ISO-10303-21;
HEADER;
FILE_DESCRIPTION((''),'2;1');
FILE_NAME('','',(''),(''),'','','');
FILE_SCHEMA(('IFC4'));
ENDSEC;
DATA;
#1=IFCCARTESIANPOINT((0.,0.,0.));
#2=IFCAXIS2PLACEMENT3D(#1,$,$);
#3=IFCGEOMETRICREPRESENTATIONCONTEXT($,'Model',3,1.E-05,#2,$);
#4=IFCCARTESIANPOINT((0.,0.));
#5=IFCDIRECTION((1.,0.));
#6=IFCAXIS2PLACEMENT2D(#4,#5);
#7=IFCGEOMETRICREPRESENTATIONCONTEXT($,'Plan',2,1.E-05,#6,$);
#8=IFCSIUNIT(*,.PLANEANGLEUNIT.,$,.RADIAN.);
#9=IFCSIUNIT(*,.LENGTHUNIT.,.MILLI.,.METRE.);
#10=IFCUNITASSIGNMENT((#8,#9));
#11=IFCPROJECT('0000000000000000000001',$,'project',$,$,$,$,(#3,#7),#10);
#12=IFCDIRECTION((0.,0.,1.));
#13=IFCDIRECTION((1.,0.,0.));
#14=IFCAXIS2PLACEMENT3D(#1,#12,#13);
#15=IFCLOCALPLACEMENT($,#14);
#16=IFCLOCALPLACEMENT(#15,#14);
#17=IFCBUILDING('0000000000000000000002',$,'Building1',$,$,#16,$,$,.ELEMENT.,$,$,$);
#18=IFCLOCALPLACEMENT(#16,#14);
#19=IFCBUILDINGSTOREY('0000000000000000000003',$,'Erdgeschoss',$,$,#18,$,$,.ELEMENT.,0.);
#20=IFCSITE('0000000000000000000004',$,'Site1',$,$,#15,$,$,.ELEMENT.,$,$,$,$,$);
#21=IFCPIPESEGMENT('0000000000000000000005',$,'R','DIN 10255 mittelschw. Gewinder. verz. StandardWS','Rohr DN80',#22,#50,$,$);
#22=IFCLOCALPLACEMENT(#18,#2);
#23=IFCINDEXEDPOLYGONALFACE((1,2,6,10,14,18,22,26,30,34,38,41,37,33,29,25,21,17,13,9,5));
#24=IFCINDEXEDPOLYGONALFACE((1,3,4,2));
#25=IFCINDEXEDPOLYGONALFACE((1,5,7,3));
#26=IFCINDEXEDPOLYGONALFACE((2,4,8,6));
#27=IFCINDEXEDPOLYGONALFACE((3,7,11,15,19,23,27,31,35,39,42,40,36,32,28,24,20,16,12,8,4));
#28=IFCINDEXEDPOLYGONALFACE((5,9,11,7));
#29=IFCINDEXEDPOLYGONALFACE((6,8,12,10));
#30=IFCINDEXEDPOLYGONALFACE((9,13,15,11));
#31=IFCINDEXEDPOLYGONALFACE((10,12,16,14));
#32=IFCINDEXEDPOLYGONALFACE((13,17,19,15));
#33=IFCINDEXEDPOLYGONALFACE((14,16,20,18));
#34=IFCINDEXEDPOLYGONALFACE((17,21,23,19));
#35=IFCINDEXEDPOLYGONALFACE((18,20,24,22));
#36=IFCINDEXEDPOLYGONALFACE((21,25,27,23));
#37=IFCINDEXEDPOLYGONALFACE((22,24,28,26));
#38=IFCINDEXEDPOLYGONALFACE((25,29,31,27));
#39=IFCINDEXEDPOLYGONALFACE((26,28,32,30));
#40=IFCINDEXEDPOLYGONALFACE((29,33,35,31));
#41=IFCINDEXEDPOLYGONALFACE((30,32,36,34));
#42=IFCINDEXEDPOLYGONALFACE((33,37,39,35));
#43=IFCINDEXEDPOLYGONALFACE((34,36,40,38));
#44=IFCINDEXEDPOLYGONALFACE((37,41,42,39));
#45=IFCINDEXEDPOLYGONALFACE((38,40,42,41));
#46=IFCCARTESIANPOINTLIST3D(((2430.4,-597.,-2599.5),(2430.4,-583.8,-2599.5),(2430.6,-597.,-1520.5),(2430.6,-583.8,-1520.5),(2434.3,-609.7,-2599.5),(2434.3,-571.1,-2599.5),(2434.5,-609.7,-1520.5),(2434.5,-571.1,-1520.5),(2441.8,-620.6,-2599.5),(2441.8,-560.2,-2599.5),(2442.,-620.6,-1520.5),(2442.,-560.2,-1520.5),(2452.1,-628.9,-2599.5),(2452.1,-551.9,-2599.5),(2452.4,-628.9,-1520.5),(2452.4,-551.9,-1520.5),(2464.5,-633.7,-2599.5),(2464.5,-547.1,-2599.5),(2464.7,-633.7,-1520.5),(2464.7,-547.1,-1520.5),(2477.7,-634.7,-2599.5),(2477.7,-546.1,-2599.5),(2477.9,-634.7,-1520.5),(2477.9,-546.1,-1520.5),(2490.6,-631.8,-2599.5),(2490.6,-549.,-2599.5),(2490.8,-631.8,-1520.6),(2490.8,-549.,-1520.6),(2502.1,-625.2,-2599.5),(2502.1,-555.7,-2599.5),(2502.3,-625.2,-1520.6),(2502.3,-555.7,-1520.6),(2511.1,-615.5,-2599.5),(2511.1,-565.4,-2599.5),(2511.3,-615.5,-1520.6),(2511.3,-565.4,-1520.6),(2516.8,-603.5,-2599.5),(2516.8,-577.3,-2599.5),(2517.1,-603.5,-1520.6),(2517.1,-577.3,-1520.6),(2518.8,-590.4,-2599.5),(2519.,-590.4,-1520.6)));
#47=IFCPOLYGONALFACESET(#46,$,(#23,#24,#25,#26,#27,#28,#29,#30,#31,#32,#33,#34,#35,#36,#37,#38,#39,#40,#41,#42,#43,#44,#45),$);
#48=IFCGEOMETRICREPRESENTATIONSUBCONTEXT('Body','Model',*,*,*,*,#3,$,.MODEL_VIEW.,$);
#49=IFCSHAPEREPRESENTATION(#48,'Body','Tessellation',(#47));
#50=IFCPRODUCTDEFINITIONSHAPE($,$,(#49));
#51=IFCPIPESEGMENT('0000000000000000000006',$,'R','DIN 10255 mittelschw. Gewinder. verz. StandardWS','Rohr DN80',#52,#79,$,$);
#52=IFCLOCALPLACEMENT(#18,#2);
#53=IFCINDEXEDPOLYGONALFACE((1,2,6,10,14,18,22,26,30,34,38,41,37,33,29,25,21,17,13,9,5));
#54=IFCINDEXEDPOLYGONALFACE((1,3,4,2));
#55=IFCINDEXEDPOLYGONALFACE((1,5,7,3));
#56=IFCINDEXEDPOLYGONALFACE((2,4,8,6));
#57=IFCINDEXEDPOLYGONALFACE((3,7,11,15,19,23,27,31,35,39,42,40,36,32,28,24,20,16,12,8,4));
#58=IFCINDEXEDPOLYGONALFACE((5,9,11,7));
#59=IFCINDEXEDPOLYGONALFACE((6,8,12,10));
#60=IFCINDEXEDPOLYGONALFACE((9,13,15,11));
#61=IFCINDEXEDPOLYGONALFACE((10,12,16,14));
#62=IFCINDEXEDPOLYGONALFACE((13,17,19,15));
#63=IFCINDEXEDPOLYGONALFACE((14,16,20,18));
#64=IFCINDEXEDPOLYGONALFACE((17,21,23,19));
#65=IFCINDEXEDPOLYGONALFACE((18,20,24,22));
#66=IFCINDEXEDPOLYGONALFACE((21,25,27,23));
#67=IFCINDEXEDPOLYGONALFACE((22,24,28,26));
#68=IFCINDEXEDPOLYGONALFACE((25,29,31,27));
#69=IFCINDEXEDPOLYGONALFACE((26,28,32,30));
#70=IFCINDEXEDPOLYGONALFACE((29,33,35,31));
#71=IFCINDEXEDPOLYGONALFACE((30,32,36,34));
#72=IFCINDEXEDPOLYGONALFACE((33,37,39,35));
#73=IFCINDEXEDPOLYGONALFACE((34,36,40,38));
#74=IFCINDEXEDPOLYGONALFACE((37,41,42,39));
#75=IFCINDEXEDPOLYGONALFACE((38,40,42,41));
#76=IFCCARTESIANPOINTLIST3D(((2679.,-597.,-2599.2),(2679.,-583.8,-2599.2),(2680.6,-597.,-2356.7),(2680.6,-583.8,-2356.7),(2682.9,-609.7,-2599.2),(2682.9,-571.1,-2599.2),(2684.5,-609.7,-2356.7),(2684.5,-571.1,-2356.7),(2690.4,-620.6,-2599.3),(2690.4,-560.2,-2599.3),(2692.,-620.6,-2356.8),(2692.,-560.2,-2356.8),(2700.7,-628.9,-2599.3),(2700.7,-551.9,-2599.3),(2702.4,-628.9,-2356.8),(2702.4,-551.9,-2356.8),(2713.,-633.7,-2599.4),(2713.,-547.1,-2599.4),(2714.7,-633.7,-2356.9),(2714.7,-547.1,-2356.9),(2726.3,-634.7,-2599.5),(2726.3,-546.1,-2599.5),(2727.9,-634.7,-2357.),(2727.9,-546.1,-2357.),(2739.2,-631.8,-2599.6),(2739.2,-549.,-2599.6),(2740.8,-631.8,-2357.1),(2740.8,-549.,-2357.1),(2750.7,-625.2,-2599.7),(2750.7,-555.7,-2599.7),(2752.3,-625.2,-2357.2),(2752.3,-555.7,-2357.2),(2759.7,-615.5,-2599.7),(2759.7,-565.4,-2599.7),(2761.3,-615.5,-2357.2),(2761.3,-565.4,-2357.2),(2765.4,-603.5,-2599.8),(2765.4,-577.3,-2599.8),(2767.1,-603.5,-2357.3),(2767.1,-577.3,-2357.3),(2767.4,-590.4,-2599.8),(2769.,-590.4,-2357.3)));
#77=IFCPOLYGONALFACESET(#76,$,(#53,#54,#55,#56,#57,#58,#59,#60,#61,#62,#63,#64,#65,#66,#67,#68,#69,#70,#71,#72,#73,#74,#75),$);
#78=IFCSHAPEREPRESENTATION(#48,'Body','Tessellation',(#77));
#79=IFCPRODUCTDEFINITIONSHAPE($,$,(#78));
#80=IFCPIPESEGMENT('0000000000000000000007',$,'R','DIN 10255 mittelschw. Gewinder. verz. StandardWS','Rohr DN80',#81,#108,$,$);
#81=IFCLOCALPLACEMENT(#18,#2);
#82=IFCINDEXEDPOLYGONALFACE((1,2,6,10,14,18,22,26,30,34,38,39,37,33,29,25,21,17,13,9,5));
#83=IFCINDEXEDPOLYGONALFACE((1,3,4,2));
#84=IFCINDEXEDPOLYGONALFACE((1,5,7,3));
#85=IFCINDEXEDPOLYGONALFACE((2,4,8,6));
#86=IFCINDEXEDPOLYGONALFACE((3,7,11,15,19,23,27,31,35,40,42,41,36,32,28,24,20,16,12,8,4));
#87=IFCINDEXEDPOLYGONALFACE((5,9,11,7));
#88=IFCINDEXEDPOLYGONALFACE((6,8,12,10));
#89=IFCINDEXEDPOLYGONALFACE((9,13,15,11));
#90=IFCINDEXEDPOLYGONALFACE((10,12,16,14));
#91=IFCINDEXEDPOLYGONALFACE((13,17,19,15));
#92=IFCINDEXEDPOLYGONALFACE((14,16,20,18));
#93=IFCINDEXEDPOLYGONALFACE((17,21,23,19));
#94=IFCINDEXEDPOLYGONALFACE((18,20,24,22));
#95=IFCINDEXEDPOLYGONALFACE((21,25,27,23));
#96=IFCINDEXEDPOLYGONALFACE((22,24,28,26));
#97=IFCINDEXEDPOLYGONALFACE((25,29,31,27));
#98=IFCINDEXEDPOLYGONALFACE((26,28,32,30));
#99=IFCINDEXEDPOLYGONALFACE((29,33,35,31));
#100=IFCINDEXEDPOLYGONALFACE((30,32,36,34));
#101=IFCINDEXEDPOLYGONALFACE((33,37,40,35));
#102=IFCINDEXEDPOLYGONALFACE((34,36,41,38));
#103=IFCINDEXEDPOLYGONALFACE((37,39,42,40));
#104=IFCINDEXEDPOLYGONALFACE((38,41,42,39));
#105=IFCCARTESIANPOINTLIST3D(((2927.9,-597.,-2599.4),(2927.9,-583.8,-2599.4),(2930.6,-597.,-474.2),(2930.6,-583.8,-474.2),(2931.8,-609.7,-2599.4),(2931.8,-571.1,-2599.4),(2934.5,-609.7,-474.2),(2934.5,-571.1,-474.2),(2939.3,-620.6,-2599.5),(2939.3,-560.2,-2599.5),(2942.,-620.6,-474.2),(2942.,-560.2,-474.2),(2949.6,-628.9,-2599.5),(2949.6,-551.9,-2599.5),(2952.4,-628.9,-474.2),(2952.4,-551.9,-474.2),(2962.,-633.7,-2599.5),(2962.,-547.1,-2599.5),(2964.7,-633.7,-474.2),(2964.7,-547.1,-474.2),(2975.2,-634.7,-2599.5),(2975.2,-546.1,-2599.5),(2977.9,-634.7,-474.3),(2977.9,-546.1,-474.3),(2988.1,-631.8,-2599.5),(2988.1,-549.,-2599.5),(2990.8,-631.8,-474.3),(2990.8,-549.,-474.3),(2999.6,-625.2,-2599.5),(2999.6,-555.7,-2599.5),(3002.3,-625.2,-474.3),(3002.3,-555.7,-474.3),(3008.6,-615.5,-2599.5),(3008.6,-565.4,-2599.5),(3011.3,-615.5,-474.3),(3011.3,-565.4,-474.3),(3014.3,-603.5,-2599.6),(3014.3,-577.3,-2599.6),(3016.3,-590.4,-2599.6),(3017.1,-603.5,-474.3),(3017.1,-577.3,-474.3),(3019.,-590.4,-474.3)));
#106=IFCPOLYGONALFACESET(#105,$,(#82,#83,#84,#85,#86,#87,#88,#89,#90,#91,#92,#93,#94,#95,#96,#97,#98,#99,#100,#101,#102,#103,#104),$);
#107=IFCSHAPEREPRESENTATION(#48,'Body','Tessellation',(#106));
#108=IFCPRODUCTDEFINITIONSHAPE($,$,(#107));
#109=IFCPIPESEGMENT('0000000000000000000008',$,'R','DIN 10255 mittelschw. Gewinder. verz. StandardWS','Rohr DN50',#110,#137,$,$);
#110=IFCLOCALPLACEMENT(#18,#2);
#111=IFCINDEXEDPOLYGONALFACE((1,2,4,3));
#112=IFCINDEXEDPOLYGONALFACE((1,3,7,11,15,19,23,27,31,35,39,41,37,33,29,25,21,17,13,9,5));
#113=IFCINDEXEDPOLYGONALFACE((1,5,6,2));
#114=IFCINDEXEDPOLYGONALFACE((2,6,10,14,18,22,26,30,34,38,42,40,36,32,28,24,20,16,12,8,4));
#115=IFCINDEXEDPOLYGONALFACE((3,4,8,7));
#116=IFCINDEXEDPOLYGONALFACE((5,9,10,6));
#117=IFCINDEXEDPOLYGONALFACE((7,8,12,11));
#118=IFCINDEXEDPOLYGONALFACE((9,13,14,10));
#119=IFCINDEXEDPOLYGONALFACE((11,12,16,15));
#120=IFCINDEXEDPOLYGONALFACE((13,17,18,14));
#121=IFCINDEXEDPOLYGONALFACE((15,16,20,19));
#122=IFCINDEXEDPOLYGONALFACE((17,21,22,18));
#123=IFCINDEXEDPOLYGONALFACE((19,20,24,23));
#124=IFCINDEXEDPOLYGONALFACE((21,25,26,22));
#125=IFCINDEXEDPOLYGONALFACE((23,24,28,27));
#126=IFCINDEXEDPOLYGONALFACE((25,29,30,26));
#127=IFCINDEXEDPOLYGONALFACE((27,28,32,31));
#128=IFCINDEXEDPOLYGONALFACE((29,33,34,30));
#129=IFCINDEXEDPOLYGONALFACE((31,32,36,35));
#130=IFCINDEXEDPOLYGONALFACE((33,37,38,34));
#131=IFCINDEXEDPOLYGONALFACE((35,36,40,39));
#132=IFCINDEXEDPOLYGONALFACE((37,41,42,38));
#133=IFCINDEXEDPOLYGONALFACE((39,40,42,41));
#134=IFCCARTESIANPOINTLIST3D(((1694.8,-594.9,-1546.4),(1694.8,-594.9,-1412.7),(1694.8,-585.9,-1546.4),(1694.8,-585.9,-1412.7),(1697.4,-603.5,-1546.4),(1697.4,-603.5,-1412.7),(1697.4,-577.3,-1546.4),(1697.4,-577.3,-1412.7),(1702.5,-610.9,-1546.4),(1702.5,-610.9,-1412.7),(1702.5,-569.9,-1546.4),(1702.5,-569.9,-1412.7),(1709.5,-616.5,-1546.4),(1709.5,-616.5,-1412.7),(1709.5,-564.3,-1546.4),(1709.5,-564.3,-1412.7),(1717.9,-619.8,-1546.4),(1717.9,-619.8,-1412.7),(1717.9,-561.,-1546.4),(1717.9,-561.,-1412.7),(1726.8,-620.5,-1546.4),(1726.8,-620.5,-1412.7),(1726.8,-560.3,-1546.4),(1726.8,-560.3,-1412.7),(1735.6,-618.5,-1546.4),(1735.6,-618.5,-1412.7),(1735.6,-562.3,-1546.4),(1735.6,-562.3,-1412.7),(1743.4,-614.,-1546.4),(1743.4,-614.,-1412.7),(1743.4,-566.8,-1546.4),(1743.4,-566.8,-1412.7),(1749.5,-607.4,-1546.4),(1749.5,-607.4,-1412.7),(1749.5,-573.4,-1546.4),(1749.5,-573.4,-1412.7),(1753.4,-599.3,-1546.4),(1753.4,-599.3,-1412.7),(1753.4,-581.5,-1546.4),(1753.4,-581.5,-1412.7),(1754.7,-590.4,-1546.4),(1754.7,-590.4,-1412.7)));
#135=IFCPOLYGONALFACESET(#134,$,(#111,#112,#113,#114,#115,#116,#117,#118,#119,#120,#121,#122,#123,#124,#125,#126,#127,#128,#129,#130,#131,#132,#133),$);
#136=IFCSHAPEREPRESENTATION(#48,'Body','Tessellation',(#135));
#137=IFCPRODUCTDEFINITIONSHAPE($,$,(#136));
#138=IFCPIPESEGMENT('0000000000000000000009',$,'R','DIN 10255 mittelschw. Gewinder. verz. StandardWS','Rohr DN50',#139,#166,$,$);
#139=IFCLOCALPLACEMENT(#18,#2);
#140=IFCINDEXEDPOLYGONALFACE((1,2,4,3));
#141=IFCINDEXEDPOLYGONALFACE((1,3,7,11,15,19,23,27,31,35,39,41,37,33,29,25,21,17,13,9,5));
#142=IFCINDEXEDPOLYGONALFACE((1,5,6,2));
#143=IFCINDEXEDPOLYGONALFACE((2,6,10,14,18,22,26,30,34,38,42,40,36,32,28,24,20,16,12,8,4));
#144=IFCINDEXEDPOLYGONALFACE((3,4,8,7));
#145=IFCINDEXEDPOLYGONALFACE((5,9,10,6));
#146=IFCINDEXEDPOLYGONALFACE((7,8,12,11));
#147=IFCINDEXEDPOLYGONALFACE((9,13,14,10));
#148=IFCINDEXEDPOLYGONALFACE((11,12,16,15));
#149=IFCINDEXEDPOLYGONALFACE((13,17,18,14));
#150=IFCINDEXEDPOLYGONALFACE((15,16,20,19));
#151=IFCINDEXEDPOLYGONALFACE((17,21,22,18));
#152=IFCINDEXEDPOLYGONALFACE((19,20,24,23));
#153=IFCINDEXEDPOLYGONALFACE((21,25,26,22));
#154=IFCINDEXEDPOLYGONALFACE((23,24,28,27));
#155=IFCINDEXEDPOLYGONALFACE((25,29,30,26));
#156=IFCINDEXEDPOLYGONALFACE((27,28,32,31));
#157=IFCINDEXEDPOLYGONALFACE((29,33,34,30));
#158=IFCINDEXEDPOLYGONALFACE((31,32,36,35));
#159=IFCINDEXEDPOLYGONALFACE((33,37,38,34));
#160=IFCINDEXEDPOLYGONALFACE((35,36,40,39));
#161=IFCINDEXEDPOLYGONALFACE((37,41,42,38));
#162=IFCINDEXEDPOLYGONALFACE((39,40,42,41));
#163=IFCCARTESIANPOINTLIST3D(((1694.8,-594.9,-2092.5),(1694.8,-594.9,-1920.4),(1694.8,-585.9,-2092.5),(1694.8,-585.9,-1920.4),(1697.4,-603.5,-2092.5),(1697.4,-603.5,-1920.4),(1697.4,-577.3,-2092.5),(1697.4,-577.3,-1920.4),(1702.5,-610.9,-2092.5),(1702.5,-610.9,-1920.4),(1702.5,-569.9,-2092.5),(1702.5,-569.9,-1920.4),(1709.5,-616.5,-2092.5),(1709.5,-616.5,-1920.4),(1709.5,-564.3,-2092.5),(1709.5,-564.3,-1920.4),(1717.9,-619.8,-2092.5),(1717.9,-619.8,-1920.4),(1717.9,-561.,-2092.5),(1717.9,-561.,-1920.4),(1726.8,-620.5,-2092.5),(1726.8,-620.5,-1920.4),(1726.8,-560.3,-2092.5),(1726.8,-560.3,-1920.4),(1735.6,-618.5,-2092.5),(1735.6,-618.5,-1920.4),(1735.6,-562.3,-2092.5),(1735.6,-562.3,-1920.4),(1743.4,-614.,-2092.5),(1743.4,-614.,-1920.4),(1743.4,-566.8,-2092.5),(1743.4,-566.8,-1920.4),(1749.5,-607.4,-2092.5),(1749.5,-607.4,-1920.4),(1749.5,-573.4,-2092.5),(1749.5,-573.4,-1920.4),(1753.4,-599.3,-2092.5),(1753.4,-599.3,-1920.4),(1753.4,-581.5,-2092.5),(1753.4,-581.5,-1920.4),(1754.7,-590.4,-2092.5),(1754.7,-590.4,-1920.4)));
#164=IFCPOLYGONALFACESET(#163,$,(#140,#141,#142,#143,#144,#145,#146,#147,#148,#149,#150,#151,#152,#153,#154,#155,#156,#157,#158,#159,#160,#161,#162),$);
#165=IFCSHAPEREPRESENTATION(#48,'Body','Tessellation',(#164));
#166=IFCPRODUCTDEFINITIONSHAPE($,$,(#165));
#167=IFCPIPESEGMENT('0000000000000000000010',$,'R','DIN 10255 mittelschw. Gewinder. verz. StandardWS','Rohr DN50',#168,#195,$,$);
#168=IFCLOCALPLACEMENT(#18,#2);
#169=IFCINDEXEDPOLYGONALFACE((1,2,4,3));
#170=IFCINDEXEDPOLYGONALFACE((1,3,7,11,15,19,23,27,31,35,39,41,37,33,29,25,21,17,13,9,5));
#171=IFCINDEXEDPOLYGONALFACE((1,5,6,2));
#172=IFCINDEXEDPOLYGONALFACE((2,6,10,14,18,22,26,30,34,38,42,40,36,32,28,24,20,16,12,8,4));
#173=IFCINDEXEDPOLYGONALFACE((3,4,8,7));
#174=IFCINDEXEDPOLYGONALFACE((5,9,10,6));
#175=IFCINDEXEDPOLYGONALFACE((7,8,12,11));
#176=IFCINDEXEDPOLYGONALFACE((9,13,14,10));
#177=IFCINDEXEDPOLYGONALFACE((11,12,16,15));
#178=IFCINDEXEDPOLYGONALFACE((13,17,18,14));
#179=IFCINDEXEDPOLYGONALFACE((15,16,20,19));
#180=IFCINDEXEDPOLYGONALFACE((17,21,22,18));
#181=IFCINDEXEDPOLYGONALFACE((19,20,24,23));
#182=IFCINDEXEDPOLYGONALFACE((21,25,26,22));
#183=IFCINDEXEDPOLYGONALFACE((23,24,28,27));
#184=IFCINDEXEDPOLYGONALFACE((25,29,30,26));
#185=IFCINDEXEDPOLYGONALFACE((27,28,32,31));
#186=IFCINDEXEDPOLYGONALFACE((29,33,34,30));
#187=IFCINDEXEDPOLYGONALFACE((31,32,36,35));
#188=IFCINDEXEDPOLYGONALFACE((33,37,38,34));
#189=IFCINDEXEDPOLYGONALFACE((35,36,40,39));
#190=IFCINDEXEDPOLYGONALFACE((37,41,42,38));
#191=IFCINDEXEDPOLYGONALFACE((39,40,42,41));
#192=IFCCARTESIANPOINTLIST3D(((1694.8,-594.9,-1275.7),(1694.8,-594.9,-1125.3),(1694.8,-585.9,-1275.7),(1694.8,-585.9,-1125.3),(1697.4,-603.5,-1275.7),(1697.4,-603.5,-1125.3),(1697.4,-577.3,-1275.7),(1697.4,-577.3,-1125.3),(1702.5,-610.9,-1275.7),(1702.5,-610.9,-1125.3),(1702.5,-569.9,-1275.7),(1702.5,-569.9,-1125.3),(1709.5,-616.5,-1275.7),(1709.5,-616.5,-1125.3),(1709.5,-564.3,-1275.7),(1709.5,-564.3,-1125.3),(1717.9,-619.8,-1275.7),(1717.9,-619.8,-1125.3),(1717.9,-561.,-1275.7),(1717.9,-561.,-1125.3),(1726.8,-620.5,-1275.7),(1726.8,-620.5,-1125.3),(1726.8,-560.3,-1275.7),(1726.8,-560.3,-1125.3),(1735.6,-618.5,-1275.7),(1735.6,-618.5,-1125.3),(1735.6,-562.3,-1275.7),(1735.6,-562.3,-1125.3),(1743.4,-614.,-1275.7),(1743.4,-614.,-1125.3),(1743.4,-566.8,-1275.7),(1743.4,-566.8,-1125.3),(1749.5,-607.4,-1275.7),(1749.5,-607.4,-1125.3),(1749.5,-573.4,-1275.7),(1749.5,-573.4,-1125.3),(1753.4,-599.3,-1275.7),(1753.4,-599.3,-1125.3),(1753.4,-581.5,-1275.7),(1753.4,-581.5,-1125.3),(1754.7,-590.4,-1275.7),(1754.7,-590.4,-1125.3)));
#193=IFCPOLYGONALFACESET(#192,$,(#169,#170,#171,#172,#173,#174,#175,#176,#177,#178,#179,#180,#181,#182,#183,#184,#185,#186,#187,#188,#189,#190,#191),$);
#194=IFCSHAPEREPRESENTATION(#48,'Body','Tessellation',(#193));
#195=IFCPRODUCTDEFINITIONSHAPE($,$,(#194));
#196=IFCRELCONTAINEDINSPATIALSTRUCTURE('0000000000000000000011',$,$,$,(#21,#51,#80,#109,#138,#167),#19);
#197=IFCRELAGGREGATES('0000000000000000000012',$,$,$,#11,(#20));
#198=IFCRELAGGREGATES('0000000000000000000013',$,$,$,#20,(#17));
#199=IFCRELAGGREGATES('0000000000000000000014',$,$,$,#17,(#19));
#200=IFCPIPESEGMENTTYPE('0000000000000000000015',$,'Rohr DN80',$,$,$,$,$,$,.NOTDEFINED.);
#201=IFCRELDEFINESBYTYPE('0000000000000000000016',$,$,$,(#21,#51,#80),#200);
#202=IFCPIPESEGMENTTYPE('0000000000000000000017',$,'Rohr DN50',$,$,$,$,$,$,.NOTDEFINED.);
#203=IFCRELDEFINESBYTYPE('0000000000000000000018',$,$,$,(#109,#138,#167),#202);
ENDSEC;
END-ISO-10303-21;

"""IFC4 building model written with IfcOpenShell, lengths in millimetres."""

from ifc_helpers import new_model, si_unit, frame, origin, origin_with_axes, origin_2d_with_axis, place, context, subcontext, project, spatial, circle, extrude, type_object, element, save


model = new_model("IFC4")

# Units and contexts
model_context = context("Model", 3, precision=1e-05, world=origin())
plan_context = context("Plan", 2, precision=1e-05, world=origin_2d_with_axis())
body_context = subcontext(model_context, "Body", "Model", "MODEL_VIEW")
ifc_project = project(units=[si_unit("PLANEANGLEUNIT", "RADIAN"), si_unit("LENGTHUNIT", "METRE", prefix="MILLI")], contexts=[model_context, plan_context])

# Site, building, storey
site_placement = place(None, origin_with_axes())
site = spatial("IfcSite", under=ifc_project, at=site_placement, Name="Site1", CompositionType="ELEMENT")
building_placement = place(site_placement, origin_with_axes())
building = spatial("IfcBuilding", under=site, at=building_placement, Name="Building1", CompositionType="ELEMENT")
storey_placement = place(building_placement, origin_with_axes())
storey = spatial("IfcBuildingStorey", under=building, at=storey_placement, Name="Erdgeschoss", CompositionType="ELEMENT", Elevation=0.0)

# Pipe segments
pipe_segment_type_1 = type_object("IfcPipeSegmentType", Name="Rohr DN80", PredefinedType="NOTDEFINED")
pipe_segment_1_placement = place(storey_placement, frame((2474.5, -590.6, -2060.0), z_axis=(0.0, 0.0, 1.0), x_axis=(1.0, 0.0, 0.0)))
element("IfcPipeSegment", 1, at=pipe_segment_1_placement, inside=storey, type_object=pipe_segment_type_1, Name="R", Description="DIN 10255 mittelschw. Gewinder. verz. StandardWS", ObjectType="Rohr DN80", context=body_context, shape_type="SolidModel", body=[
    extrude(circle(Radius=44.5, at=origin_2d_with_axis()), frame((-0.1, 0.2, -539.5), z_axis=(0.000217, 0.0, 1.0), x_axis=(1.0, 0.0, 0.0)), (0.0, 0.0, 1.0), 1079.0),
])
pipe_segment_2_placement = place(storey_placement, frame((2723.8, -590.6, -2478.2), z_axis=(0.0, 0.0, 1.0), x_axis=(1.0, 0.0, 0.0)))
element("IfcPipeSegment", 2, at=pipe_segment_2_placement, inside=storey, type_object=pipe_segment_type_1, Name="R", Description="DIN 10255 mittelschw. Gewinder. verz. StandardWS", ObjectType="Rohr DN80", context=body_context, shape_type="SolidModel", body=[
    extrude(circle(Radius=44.5, at=origin_2d_with_axis()), frame((-0.8, 0.1, -121.3), z_axis=(0.006764, 0.0, 0.999977), x_axis=(1.0, 0.0, 0.0)), (0.0, 0.0, 1.0), 242.5),
])
pipe_segment_3_placement = place(storey_placement, frame((2973.2, -590.6, -1536.9), z_axis=(0.0, 0.0, 1.0), x_axis=(1.0, 0.0, 0.0)))
element("IfcPipeSegment", 3, at=pipe_segment_3_placement, inside=storey, type_object=pipe_segment_type_1, Name="R", Description="DIN 10255 mittelschw. Gewinder. verz. StandardWS", ObjectType="Rohr DN80", context=body_context, shape_type="SolidModel", body=[
    extrude(circle(Radius=44.5, at=origin_2d_with_axis()), frame((-1.4, 0.1, -1062.6), z_axis=(0.001276, 0.0, 0.999999), x_axis=(1.0, 0.0, 0.0)), (0.0, 0.0, 1.0), 2125.3),
])
pipe_segment_type_2 = type_object("IfcPipeSegmentType", Name="Rohr DN50", PredefinedType="NOTDEFINED")
pipe_segment_4_placement = place(storey_placement, frame((1724.6, -590.6, -1479.6), z_axis=(0.0, 0.0, 1.0), x_axis=(1.0, 0.0, 0.0)))
element("IfcPipeSegment", 4, at=pipe_segment_4_placement, inside=storey, type_object=pipe_segment_type_2, Name="R", Description="DIN 10255 mittelschw. Gewinder. verz. StandardWS", ObjectType="Rohr DN50", context=body_context, shape_type="SolidModel", body=[
    extrude(circle(Radius=30.1, at=origin_2d_with_axis()), frame((0.0, 0.1, -66.8), z_axis=(0.0, 0.0, 1.0), x_axis=(1.0, 0.0, 0.0)), (0.0, 0.0, 1.0), 133.7),
])
pipe_segment_5_placement = place(storey_placement, frame((1724.6, -590.6, -2006.4), z_axis=(0.0, 0.0, 1.0), x_axis=(1.0, 0.0, 0.0)))
element("IfcPipeSegment", 5, at=pipe_segment_5_placement, inside=storey, type_object=pipe_segment_type_2, Name="R", Description="DIN 10255 mittelschw. Gewinder. verz. StandardWS", ObjectType="Rohr DN50", context=body_context, shape_type="SolidModel", body=[
    extrude(circle(Radius=30.1, at=origin_2d_with_axis()), frame((0.0, 0.1, -86.1), z_axis=(0.0, 0.0, 1.0), x_axis=(1.0, 0.0, 0.0)), (0.0, 0.0, 1.0), 172.1),
])
pipe_segment_6_placement = place(storey_placement, frame((1724.6, -590.6, -1200.5), z_axis=(0.0, 0.0, 1.0), x_axis=(1.0, 0.0, 0.0)))
element("IfcPipeSegment", 6, at=pipe_segment_6_placement, inside=storey, type_object=pipe_segment_type_2, Name="R", Description="DIN 10255 mittelschw. Gewinder. verz. StandardWS", ObjectType="Rohr DN50", context=body_context, shape_type="SolidModel", body=[
    extrude(circle(Radius=30.1, at=origin_2d_with_axis()), frame((0.0, 0.1, -75.2), z_axis=(0.0, 0.0, 1.0), x_axis=(1.0, 0.0, 0.0)), (0.0, 0.0, 1.0), 150.5),
])

save(model, "model.ifc")
